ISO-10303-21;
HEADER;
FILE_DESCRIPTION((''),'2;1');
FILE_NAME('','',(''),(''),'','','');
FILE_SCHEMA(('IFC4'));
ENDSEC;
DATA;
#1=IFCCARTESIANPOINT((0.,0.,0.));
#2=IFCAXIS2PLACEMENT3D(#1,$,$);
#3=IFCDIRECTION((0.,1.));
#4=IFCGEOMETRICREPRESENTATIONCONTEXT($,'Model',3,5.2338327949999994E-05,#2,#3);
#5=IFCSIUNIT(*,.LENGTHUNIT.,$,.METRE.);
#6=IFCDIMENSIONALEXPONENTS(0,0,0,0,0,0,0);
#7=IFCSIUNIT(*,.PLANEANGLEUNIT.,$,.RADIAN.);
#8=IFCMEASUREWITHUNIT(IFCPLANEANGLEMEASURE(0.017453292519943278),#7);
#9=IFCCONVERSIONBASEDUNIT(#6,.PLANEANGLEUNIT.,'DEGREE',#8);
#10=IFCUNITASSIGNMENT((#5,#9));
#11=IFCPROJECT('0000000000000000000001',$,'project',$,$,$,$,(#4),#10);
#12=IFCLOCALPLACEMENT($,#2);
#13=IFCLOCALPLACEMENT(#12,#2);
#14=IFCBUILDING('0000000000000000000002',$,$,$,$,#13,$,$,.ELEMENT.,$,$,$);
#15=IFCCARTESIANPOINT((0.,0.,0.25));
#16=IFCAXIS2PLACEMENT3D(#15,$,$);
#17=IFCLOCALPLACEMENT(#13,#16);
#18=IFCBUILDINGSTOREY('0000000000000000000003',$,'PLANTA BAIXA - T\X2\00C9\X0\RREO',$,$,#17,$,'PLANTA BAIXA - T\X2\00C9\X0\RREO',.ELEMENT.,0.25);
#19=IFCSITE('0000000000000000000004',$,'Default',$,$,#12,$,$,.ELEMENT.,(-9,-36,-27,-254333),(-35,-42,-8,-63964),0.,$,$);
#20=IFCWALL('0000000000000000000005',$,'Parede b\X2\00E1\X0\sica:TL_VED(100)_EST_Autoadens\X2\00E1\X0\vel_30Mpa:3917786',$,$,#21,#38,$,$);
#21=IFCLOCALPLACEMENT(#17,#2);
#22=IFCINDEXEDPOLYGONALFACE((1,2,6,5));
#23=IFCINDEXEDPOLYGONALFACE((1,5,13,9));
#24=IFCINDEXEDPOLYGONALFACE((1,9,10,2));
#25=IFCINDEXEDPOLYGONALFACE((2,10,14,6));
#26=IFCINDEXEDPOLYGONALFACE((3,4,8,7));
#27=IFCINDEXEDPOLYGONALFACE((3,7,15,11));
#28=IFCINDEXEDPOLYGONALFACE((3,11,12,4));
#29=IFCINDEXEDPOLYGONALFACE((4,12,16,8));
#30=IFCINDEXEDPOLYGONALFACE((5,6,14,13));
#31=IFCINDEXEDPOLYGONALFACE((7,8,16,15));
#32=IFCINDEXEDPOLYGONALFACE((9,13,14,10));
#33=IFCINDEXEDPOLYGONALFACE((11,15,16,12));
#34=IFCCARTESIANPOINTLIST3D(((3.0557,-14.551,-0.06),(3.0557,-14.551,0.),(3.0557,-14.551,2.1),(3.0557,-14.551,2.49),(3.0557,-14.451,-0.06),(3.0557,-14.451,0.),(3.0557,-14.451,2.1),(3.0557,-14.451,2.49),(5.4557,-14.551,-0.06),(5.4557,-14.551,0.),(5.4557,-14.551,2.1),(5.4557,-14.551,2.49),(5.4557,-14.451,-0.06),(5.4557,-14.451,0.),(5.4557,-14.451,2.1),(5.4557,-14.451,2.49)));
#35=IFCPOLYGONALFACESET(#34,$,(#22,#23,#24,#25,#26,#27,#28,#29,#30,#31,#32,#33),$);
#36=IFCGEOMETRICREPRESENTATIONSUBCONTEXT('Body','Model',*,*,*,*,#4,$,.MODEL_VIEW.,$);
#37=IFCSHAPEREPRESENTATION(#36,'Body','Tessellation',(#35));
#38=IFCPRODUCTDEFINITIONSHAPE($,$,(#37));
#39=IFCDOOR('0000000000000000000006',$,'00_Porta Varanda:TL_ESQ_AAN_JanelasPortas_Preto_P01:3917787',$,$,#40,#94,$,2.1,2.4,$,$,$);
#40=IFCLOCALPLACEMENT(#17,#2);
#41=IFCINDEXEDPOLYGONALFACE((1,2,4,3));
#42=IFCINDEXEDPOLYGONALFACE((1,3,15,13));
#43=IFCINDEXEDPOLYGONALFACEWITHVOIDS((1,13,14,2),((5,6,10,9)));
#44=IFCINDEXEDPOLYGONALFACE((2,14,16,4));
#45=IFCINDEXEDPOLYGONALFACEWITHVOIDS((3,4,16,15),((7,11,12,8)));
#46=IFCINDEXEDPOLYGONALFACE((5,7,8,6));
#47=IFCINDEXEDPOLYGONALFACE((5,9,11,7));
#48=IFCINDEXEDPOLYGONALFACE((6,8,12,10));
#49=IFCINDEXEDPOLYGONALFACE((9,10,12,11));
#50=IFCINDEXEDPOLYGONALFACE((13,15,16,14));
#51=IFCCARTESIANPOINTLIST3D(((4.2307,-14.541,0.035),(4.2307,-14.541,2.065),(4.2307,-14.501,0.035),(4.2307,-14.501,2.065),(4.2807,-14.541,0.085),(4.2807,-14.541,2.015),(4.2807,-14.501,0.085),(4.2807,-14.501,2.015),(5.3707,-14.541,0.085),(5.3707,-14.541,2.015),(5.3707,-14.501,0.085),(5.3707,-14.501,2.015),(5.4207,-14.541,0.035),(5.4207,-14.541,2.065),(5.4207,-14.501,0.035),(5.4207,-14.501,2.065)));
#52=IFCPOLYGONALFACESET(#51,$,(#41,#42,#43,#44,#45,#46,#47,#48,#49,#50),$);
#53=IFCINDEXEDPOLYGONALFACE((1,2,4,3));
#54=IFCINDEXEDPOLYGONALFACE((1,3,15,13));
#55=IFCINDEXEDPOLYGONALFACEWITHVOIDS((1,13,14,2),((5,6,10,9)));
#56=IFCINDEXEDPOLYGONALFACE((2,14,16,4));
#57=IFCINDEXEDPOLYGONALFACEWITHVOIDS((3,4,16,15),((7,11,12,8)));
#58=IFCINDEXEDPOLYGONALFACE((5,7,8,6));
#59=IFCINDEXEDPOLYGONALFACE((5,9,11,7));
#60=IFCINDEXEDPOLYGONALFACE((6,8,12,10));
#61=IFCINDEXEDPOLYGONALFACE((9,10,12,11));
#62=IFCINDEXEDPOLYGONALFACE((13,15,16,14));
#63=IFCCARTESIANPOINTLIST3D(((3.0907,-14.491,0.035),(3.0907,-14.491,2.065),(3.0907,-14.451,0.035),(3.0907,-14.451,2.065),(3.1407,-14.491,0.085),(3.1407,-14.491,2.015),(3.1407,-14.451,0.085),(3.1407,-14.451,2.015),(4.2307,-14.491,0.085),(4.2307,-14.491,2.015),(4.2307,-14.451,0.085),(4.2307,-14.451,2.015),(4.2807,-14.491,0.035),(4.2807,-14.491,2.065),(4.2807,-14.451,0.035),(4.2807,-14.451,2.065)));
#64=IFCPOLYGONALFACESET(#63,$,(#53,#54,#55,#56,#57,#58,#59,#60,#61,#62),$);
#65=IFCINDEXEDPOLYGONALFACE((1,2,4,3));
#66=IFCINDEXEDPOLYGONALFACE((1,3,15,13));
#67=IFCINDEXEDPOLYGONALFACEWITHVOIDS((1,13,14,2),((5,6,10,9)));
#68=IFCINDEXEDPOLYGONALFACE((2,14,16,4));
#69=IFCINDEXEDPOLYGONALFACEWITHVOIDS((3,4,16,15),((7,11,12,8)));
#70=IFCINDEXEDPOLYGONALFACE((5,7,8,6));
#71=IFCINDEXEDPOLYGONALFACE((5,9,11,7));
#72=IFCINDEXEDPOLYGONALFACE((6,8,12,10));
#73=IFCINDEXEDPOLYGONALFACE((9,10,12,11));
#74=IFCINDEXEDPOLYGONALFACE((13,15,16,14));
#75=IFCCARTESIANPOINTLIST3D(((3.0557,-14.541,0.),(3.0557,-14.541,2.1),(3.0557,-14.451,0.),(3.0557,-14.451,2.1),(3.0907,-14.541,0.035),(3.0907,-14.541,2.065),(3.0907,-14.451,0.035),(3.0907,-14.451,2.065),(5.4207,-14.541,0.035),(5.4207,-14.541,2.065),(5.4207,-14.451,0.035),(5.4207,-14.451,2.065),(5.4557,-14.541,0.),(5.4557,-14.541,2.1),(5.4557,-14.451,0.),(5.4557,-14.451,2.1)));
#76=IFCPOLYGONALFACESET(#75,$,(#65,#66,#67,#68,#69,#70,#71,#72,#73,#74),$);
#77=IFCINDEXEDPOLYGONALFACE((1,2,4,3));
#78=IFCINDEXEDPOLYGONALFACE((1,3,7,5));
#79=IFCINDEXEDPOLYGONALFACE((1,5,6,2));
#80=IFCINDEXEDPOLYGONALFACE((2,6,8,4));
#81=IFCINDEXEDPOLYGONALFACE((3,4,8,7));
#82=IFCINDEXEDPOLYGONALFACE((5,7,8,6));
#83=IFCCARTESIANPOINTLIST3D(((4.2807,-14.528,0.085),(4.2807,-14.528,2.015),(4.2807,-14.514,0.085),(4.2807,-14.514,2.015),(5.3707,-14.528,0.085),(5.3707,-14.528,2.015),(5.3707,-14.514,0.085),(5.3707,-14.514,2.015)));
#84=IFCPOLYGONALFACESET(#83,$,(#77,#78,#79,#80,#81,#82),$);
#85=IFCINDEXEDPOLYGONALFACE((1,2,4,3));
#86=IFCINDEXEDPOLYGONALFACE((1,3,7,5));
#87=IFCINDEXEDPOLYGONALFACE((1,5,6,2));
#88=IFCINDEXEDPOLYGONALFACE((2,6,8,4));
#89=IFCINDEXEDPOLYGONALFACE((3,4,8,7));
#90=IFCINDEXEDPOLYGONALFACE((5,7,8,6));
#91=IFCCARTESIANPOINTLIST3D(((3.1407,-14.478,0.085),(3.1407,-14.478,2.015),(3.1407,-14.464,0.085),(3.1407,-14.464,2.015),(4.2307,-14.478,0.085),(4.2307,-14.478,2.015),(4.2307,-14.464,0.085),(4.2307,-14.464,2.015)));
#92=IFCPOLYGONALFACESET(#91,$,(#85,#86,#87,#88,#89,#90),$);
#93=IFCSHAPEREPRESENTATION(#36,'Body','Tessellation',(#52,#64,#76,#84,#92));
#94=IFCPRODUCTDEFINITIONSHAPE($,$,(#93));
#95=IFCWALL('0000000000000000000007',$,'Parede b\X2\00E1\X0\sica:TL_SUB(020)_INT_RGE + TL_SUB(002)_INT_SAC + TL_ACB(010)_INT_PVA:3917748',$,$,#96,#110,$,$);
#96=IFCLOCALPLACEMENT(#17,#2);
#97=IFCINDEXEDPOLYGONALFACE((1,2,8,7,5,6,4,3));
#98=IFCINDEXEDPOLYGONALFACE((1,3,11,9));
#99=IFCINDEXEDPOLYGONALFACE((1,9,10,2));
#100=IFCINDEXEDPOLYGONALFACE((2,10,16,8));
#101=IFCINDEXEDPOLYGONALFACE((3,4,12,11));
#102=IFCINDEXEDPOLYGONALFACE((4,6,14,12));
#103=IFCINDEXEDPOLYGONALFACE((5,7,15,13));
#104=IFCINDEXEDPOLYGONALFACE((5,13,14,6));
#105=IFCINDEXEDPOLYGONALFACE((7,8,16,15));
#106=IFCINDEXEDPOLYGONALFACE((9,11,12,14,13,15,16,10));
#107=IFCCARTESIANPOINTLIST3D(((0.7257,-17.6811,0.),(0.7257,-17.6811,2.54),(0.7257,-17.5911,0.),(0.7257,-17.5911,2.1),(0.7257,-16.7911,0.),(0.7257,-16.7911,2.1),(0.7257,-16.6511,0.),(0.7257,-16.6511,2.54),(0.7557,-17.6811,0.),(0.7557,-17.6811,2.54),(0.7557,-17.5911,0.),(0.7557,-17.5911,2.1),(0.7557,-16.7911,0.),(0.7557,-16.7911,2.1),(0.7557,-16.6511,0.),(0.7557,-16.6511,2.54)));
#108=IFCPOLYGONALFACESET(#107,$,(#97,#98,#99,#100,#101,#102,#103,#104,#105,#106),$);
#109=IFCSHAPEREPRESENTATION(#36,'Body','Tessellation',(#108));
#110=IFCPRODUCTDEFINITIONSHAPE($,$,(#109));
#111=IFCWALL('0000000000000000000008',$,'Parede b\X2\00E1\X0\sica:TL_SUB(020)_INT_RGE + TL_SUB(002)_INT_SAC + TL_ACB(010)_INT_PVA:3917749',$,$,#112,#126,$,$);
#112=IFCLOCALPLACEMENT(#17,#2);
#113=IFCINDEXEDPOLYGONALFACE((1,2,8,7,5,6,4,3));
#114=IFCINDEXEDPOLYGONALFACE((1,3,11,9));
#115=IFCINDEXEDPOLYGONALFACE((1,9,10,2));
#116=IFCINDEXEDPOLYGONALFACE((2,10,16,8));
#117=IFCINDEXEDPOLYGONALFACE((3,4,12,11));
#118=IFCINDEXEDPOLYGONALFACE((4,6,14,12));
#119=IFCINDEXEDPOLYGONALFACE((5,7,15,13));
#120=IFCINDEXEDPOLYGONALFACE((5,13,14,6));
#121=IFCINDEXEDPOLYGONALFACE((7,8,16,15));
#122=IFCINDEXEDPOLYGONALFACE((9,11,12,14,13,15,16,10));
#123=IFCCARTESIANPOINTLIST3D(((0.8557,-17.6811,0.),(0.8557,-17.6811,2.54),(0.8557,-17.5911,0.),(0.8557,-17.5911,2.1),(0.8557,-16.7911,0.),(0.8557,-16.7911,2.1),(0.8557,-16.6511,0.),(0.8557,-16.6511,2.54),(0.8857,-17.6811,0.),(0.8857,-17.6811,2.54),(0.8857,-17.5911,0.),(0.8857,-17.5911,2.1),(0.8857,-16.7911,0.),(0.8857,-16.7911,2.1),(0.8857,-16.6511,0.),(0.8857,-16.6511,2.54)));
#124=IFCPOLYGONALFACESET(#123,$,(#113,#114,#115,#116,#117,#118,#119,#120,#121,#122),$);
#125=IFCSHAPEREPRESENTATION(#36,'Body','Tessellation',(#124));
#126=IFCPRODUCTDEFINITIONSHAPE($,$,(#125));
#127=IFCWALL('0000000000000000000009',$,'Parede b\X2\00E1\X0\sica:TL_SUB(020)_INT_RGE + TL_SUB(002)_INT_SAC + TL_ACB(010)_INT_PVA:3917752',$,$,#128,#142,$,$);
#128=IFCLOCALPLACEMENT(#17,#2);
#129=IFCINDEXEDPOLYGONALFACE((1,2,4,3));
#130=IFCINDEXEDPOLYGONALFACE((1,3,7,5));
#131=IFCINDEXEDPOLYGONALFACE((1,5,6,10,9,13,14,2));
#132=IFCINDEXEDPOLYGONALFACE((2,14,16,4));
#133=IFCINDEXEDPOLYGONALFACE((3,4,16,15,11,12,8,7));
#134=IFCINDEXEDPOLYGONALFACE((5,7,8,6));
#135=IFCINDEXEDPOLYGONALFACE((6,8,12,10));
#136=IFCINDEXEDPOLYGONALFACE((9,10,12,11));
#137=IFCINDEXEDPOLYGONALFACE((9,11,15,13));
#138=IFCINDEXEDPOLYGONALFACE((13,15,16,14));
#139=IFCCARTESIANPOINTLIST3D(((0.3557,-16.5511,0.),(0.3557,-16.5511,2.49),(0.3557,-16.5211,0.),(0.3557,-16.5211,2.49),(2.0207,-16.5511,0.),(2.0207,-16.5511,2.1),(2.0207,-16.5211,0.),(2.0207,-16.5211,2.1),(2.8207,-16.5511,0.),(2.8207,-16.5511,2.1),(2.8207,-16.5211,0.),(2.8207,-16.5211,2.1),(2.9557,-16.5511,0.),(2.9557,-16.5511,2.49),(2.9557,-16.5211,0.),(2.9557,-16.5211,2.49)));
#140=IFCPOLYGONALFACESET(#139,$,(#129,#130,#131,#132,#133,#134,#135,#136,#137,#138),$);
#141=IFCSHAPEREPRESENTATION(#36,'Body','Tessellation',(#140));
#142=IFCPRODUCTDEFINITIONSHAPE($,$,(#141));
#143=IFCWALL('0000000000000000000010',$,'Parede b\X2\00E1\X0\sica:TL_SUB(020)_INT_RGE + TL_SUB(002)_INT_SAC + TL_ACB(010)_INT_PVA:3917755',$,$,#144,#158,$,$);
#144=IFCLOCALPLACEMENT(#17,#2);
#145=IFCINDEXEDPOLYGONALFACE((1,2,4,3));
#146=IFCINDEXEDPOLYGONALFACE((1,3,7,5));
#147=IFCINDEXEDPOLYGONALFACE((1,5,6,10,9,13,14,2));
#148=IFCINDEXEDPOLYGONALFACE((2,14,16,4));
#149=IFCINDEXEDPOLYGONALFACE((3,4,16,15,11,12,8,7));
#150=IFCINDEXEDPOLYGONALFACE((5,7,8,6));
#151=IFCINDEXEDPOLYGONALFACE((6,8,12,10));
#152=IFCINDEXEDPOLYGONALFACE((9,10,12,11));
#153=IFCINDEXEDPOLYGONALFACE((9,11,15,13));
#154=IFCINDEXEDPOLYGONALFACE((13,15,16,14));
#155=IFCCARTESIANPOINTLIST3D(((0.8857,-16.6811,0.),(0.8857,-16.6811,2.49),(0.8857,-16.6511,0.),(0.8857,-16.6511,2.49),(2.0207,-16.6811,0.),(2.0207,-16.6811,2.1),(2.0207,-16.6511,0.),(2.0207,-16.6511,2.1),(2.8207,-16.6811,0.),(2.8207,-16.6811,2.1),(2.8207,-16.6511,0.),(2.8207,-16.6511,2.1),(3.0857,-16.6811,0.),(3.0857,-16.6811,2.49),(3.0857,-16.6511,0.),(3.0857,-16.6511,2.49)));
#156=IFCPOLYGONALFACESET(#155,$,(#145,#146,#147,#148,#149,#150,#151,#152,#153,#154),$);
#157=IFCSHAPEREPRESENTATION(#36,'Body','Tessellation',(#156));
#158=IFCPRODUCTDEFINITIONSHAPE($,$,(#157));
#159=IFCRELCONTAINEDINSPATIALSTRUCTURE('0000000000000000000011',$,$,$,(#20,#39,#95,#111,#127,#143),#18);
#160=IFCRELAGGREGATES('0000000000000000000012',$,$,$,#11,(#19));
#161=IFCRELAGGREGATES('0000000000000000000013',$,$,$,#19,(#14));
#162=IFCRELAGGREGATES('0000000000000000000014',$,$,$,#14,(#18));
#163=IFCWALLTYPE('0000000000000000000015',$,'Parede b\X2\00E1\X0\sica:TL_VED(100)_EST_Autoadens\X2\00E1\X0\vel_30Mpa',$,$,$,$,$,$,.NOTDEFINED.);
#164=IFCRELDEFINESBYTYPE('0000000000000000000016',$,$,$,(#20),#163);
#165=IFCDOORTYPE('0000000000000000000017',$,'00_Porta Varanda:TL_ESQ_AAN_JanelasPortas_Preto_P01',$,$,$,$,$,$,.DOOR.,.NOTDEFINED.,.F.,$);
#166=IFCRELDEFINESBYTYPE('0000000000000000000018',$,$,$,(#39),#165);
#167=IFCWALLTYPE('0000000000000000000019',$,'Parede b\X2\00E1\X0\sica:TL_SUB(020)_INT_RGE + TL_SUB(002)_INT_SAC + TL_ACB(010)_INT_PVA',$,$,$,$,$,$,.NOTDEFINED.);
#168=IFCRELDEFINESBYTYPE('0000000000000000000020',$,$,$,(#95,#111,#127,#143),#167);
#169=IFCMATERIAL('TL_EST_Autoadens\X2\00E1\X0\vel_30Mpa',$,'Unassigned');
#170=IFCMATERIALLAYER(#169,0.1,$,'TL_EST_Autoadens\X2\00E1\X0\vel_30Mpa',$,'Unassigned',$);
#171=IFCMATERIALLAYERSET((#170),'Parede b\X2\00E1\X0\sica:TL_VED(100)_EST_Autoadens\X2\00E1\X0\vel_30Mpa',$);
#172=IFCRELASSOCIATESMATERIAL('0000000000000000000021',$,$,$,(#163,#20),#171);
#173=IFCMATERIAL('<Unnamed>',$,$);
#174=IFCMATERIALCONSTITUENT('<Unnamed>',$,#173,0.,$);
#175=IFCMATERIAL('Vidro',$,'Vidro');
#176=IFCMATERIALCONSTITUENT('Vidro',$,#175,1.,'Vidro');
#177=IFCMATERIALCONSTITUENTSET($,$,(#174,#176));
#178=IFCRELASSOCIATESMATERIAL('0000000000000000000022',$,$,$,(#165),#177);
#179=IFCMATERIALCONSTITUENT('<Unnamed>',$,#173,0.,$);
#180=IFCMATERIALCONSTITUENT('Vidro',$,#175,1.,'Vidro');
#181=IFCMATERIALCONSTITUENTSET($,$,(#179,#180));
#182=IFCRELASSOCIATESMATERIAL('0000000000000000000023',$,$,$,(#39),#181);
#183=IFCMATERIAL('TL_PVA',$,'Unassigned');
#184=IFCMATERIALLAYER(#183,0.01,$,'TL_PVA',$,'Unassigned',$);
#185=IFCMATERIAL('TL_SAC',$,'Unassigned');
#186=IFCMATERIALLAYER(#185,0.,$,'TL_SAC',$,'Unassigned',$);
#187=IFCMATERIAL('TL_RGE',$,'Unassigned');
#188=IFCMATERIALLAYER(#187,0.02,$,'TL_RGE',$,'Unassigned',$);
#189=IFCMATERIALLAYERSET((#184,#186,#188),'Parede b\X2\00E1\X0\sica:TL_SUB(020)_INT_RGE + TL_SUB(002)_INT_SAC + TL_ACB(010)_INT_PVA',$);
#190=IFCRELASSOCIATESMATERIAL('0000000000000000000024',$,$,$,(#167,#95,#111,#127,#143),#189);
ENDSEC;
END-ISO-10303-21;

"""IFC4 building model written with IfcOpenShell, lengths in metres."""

from ifc_helpers import new_model, entity, si_unit, converted_unit, direction, frame, frame_2d, origin, place, context, subcontext, project, spatial, polyline, rectangle, outline, extrude, source, transform, mapped, material, layer, layer_set, layer_usage, constituent, constituent_set, type_object, type_shapes, element, fill, save


model = new_model("IFC4")

# Units and contexts
model_context = context("Model", 3, precision=5.2338327949999994e-05, world=origin(), true_north=direction((0.0, 1.0)))
body_context = subcontext(model_context, "Body", "Model", "MODEL_VIEW")
ifc_project = project(units=[si_unit("LENGTHUNIT", "METRE"), converted_unit("PLANEANGLEUNIT", "DEGREE", entity("IfcPlaneAngleMeasure", 0.017453292519943278), si_unit("PLANEANGLEUNIT", "RADIAN"), dimensions=[0, 0, 0, 0, 0, 0, 0])], contexts=[model_context])

# Site, building, storey
site_placement = place(None, frame((0.0, 0.0, 0.0)))
site = spatial("IfcSite", under=ifc_project, at=site_placement, Name="Default", CompositionType="ELEMENT", RefLatitude=(-9, -36, -27, -254333), RefLongitude=(-35, -42, -8, -63964), RefElevation=0.0)
building_placement = place(site_placement, origin())
building = spatial("IfcBuilding", under=site, at=building_placement, CompositionType="ELEMENT")
storey_placement = place(building_placement, frame((0.0, 0.0, 0.25)))
storey = spatial("IfcBuildingStorey", under=building, at=storey_placement, Name="PLANTA BAIXA - TÉRREO", LongName="PLANTA BAIXA - TÉRREO", CompositionType="ELEMENT", Elevation=0.25)

# Shared definitions
ifc_material_1 = material(Name="TL_EST_Autoadensável_30Mpa", Category="Unassigned")
ifc_layer_1 = layer(ifc_material_1, 0.1, Name="TL_EST_Autoadensável_30Mpa", Category="Unassigned")
ifc_layer_set_1 = layer_set([ifc_layer_1], Name="Parede básica:TL_VED(100)_EST_Autoadensável_30Mpa")
wall_type_1 = type_object("IfcWallType", Name="Parede básica:TL_VED(100)_EST_Autoadensável_30Mpa", PredefinedType="NOTDEFINED", material=ifc_layer_set_1)

# Wall, opening, door
ifc_layer_usage_1 = layer_usage(ifc_layer_set_1, "AXIS2", "NEGATIVE", 0.05)
wall_1_placement = place(storey_placement, frame((3.0557, -14.501, -0.06)))
wall_1 = element("IfcWall", 1, at=wall_1_placement, inside=storey, type_object=wall_type_1, material=ifc_layer_usage_1, Name="Parede básica:TL_VED(100)_EST_Autoadensável_30Mpa:3917786", context=body_context, shape_type="SweptSolid", body=[
    extrude(rectangle(XDim=2.4, YDim=0.1, at=frame_2d((1.2, 0.0), x_axis=(-1.0, 0.0))), origin(), (0.0, 0.0, 1.0), 2.55),
])
opening_1_placement = place(wall_1_placement, frame((2.4, 0.05, 0.06)))
opening_1 = element("IfcOpeningElement", 2, at=opening_1_placement, cuts=wall_1, PredefinedType="OPENING", context=body_context, shape_type="SweptSolid", body=[
    extrude(rectangle(XDim=2.1, YDim=2.4, at=frame_2d((1.05, 1.2), x_axis=(1.0, 0.0))), frame((0.0, 0.0, 0.0), z_axis=(0.0, -1.0, 0.0), x_axis=(0.0, 0.0, 1.0)), (0.0, 0.0, 1.0), 0.1),
])
ifc_material_2 = material(Name="<Unnamed>")
ifc_constituent_1 = constituent(ifc_material_2, Name="<Unnamed>", fraction=0.0)
ifc_material_3 = material(Name="Vidro", Category="Vidro")
ifc_constituent_2 = constituent(ifc_material_3, Name="Vidro", Category="Vidro", fraction=1.0)
ifc_constituent_set_1 = constituent_set(constituents=[ifc_constituent_1, ifc_constituent_2])
ifc_constituent_3 = constituent(ifc_material_2, Name="<Unnamed>", fraction=0.0)
ifc_constituent_4 = constituent(ifc_material_3, Name="Vidro", Category="Vidro", fraction=1.0)
ifc_constituent_set_2 = constituent_set(constituents=[ifc_constituent_3, ifc_constituent_4])
door_type = type_object("IfcDoorType", Name="00_Porta Varanda:TL_ESQ_AAN_JanelasPortas_Preto_P01", OperationType="NOTDEFINED", ParameterTakesPrecedence=False, PredefinedType="DOOR", material=ifc_constituent_set_2)
shared_shape_1 = source(origin(), body_context, "Body", "SweptSolid", [
    extrude(outline(polyline([(-0.595, -1.015), (0.595, -1.015), (0.595, 1.015), (-0.595, 1.015), (-0.595, -1.015)]), holes=[polyline([(-0.545, 0.965), (0.545, 0.965), (0.545, -0.965), (-0.545, -0.965), (-0.545, 0.965)])]), frame((0.63, 0.09, 1.05), z_axis=(0.0, -1.0, 0.0), x_axis=(-1.0, 0.0, 0.0)), (0.0, 0.0, 1.0), 0.04),
    extrude(outline(polyline([(-0.595, -1.015), (0.595, -1.015), (0.595, 1.015), (-0.595, 1.015), (-0.595, -1.015)]), holes=[polyline([(-0.545, 0.965), (0.545, 0.965), (0.545, -0.965), (-0.545, -0.965), (-0.545, 0.965)])]), frame((1.77, 0.04, 1.05), z_axis=(0.0, -1.0, 0.0), x_axis=(1.0, 0.0, 0.0)), (0.0, 0.0, 1.0), 0.04),
    extrude(outline(polyline([(-1.2, -1.05), (1.2, -1.05), (1.2, 1.05), (-1.2, 1.05), (-1.2, -1.05)]), holes=[polyline([(-1.165, 1.015), (1.165, 1.015), (1.165, -1.015), (-1.165, -1.015), (-1.165, 1.015)])]), frame((1.2, 0.09, 1.05), z_axis=(0.0, -1.0, 0.0), x_axis=(1.0, 0.0, 0.0)), (0.0, 0.0, 1.0), 0.09),
    extrude(rectangle(XDim=1.09, YDim=0.014, at=frame_2d((0.0, 0.0), x_axis=(1.0, 0.0))), frame((0.63, 0.07, 0.085), z_axis=(0.0, 0.0, 1.0), x_axis=(-1.0, 0.0, 0.0)), (0.0, 0.0, 1.0), 1.93),
    extrude(rectangle(XDim=1.09, YDim=0.014, at=frame_2d((0.0, 0.0), x_axis=(1.0, 0.0))), frame((1.77, 0.02, 0.085), z_axis=(0.0, 0.0, 1.0), x_axis=(-1.0, 0.0, 0.0)), (0.0, 0.0, 1.0), 1.93),
])
type_shapes(door_type, [shared_shape_1])
door_placement = place(opening_1_placement, frame((0.0, 0.0, 0.0), z_axis=(0.0, 0.0, 1.0), x_axis=(-1.0, 0.0, 0.0)))
door = element("IfcDoor", 3, at=door_placement, inside=storey, type_object=door_type, material=ifc_constituent_set_1, Name="00_Porta Varanda:TL_ESQ_AAN_JanelasPortas_Preto_P01:3917787", OverallHeight=2.1, OverallWidth=2.4, context=body_context, shape_type="MappedRepresentation", body=[
    mapped(shared_shape_1, transform((0.0, 0.0, 0.0), scale=1.0)),
])
fill(opening_1, door)

# Walls, openings
ifc_material_4 = material(Name="TL_PVA", Category="Unassigned")
ifc_layer_2 = layer(ifc_material_4, 0.01, Name="TL_PVA", Category="Unassigned")
ifc_material_5 = material(Name="TL_SAC", Category="Unassigned")
ifc_layer_3 = layer(ifc_material_5, 0.0, Name="TL_SAC", Category="Unassigned")
ifc_material_6 = material(Name="TL_RGE", Category="Unassigned")
ifc_layer_4 = layer(ifc_material_6, 0.02, Name="TL_RGE", Category="Unassigned")
ifc_layer_set_2 = layer_set([ifc_layer_2, ifc_layer_3, ifc_layer_4], Name="Parede básica:TL_SUB(020)_INT_RGE + TL_SUB(002)_INT_SAC + TL_ACB(010)_INT_PVA")
ifc_layer_usage_2 = layer_usage(ifc_layer_set_2, "AXIS2", "POSITIVE", -0.015)
wall_type_2 = type_object("IfcWallType", Name="Parede básica:TL_SUB(020)_INT_RGE + TL_SUB(002)_INT_SAC + TL_ACB(010)_INT_PVA", PredefinedType="NOTDEFINED", material=ifc_layer_set_2)
wall_2_placement = place(storey_placement, frame((0.7407, -16.6511, 0.0), z_axis=(0.0, 0.0, 1.0), x_axis=(0.0, -1.0, 0.0)))
wall_2 = element("IfcWall", 4, at=wall_2_placement, inside=storey, type_object=wall_type_2, material=ifc_layer_usage_2, Name="Parede básica:TL_SUB(020)_INT_RGE + TL_SUB(002)_INT_SAC + TL_ACB(010)_INT_PVA:3917748", context=body_context, shape_type="SweptSolid", body=[
    extrude(rectangle(XDim=1.03, YDim=0.03, at=frame_2d((0.515, 0.0), x_axis=(1.0, 0.0))), origin(), (0.0, 0.0, 1.0), 2.54),
])
opening_2_placement = place(wall_2_placement, frame((-16.6511, -0.7407, 0.0)))
element("IfcOpeningElement", 5, at=opening_2_placement, cuts=wall_2, PredefinedType="OPENING", context=body_context, shape_type="SweptSolid", body=[
    extrude(rectangle(XDim=2.1, YDim=0.8, at=frame_2d((0.0, 0.0), x_axis=(0.0, 1.0))), frame((17.1911, -0.6683, 1.05), z_axis=(0.0, 1.0, 0.0), x_axis=(-1.0, 0.0, 0.0)), (0.0, 0.0, 1.0), 3.048),
])
ifc_layer_usage_3 = layer_usage(ifc_layer_set_2, "AXIS2", "POSITIVE", -0.015)
wall_3_placement = place(storey_placement, frame((0.8707, -17.6811, 0.0), z_axis=(0.0, 0.0, 1.0), x_axis=(0.0, 1.0, 0.0)))
wall_3 = element("IfcWall", 6, at=wall_3_placement, inside=storey, type_object=wall_type_2, material=ifc_layer_usage_3, Name="Parede básica:TL_SUB(020)_INT_RGE + TL_SUB(002)_INT_SAC + TL_ACB(010)_INT_PVA:3917749", context=body_context, shape_type="SweptSolid", body=[
    extrude(rectangle(XDim=1.03, YDim=0.03, at=frame_2d((0.515, 0.0), x_axis=(-1.0, 0.0))), origin(), (0.0, 0.0, 1.0), 2.54),
])
opening_3_placement = place(wall_3_placement, frame((17.6811, 0.8707, 0.0)))
element("IfcOpeningElement", 7, at=opening_3_placement, cuts=wall_3, PredefinedType="OPENING", context=body_context, shape_type="SweptSolid", body=[
    extrude(rectangle(XDim=2.1, YDim=0.8, at=frame_2d((0.0, 0.0), x_axis=(1.0, 0.0))), frame((-17.1911, -2.3797, 1.05), z_axis=(0.0, 1.0, 0.0), x_axis=(0.0, 0.0, 1.0)), (0.0, 0.0, 1.0), 3.048),
])
ifc_layer_usage_4 = layer_usage(ifc_layer_set_2, "AXIS2", "POSITIVE", -0.015)
wall_4_placement = place(storey_placement, frame((2.9557, -16.5361, 0.0), z_axis=(0.0, 0.0, 1.0), x_axis=(-1.0, 0.0, 0.0)))
wall_4 = element("IfcWall", 8, at=wall_4_placement, inside=storey, type_object=wall_type_2, material=ifc_layer_usage_4, Name="Parede básica:TL_SUB(020)_INT_RGE + TL_SUB(002)_INT_SAC + TL_ACB(010)_INT_PVA:3917752", context=body_context, shape_type="SweptSolid", body=[
    extrude(rectangle(XDim=2.6, YDim=0.03, at=frame_2d((1.3, 0.0), x_axis=(-1.0, 0.0))), origin(), (0.0, 0.0, 1.0), 2.49),
])
opening_4_placement = place(wall_4_placement, frame((2.9557, -16.5361, 0.0)))
element("IfcOpeningElement", 9, at=opening_4_placement, cuts=wall_4, PredefinedType="OPENING", context=body_context, shape_type="SweptSolid", body=[
    extrude(rectangle(XDim=2.1, YDim=0.8, at=frame_2d((0.0, 0.0), x_axis=(1.0, 0.0))), frame((-2.4207, 15.1271, 1.05), z_axis=(0.0, 1.0, 0.0), x_axis=(0.0, 0.0, 1.0)), (0.0, 0.0, 1.0), 3.048),
])
ifc_layer_usage_5 = layer_usage(ifc_layer_set_2, "AXIS2", "POSITIVE", -0.015)
wall_5_placement = place(storey_placement, frame((0.8857, -16.6661, 0.0)))
wall_5 = element("IfcWall", 10, at=wall_5_placement, inside=storey, type_object=wall_type_2, material=ifc_layer_usage_5, Name="Parede básica:TL_SUB(020)_INT_RGE + TL_SUB(002)_INT_SAC + TL_ACB(010)_INT_PVA:3917755", context=body_context, shape_type="SweptSolid", body=[
    extrude(rectangle(XDim=2.2, YDim=0.03, at=frame_2d((1.1, 0.0), x_axis=(-1.0, 0.0))), origin(), (0.0, 0.0, 1.0), 2.49),
])
opening_5_placement = place(wall_5_placement, frame((-0.8857, 16.6661, 0.0)))
element("IfcOpeningElement", 11, at=opening_5_placement, cuts=wall_5, PredefinedType="OPENING", context=body_context, shape_type="SweptSolid", body=[
    extrude(rectangle(XDim=2.1, YDim=0.8, at=frame_2d((0.0, 0.0), x_axis=(0.0, 1.0))), frame((2.4207, -18.1751, 1.05), z_axis=(0.0, 1.0, 0.0), x_axis=(-1.0, 0.0, 0.0)), (0.0, 0.0, 1.0), 3.048),
])

save(model, "model.ifc")
